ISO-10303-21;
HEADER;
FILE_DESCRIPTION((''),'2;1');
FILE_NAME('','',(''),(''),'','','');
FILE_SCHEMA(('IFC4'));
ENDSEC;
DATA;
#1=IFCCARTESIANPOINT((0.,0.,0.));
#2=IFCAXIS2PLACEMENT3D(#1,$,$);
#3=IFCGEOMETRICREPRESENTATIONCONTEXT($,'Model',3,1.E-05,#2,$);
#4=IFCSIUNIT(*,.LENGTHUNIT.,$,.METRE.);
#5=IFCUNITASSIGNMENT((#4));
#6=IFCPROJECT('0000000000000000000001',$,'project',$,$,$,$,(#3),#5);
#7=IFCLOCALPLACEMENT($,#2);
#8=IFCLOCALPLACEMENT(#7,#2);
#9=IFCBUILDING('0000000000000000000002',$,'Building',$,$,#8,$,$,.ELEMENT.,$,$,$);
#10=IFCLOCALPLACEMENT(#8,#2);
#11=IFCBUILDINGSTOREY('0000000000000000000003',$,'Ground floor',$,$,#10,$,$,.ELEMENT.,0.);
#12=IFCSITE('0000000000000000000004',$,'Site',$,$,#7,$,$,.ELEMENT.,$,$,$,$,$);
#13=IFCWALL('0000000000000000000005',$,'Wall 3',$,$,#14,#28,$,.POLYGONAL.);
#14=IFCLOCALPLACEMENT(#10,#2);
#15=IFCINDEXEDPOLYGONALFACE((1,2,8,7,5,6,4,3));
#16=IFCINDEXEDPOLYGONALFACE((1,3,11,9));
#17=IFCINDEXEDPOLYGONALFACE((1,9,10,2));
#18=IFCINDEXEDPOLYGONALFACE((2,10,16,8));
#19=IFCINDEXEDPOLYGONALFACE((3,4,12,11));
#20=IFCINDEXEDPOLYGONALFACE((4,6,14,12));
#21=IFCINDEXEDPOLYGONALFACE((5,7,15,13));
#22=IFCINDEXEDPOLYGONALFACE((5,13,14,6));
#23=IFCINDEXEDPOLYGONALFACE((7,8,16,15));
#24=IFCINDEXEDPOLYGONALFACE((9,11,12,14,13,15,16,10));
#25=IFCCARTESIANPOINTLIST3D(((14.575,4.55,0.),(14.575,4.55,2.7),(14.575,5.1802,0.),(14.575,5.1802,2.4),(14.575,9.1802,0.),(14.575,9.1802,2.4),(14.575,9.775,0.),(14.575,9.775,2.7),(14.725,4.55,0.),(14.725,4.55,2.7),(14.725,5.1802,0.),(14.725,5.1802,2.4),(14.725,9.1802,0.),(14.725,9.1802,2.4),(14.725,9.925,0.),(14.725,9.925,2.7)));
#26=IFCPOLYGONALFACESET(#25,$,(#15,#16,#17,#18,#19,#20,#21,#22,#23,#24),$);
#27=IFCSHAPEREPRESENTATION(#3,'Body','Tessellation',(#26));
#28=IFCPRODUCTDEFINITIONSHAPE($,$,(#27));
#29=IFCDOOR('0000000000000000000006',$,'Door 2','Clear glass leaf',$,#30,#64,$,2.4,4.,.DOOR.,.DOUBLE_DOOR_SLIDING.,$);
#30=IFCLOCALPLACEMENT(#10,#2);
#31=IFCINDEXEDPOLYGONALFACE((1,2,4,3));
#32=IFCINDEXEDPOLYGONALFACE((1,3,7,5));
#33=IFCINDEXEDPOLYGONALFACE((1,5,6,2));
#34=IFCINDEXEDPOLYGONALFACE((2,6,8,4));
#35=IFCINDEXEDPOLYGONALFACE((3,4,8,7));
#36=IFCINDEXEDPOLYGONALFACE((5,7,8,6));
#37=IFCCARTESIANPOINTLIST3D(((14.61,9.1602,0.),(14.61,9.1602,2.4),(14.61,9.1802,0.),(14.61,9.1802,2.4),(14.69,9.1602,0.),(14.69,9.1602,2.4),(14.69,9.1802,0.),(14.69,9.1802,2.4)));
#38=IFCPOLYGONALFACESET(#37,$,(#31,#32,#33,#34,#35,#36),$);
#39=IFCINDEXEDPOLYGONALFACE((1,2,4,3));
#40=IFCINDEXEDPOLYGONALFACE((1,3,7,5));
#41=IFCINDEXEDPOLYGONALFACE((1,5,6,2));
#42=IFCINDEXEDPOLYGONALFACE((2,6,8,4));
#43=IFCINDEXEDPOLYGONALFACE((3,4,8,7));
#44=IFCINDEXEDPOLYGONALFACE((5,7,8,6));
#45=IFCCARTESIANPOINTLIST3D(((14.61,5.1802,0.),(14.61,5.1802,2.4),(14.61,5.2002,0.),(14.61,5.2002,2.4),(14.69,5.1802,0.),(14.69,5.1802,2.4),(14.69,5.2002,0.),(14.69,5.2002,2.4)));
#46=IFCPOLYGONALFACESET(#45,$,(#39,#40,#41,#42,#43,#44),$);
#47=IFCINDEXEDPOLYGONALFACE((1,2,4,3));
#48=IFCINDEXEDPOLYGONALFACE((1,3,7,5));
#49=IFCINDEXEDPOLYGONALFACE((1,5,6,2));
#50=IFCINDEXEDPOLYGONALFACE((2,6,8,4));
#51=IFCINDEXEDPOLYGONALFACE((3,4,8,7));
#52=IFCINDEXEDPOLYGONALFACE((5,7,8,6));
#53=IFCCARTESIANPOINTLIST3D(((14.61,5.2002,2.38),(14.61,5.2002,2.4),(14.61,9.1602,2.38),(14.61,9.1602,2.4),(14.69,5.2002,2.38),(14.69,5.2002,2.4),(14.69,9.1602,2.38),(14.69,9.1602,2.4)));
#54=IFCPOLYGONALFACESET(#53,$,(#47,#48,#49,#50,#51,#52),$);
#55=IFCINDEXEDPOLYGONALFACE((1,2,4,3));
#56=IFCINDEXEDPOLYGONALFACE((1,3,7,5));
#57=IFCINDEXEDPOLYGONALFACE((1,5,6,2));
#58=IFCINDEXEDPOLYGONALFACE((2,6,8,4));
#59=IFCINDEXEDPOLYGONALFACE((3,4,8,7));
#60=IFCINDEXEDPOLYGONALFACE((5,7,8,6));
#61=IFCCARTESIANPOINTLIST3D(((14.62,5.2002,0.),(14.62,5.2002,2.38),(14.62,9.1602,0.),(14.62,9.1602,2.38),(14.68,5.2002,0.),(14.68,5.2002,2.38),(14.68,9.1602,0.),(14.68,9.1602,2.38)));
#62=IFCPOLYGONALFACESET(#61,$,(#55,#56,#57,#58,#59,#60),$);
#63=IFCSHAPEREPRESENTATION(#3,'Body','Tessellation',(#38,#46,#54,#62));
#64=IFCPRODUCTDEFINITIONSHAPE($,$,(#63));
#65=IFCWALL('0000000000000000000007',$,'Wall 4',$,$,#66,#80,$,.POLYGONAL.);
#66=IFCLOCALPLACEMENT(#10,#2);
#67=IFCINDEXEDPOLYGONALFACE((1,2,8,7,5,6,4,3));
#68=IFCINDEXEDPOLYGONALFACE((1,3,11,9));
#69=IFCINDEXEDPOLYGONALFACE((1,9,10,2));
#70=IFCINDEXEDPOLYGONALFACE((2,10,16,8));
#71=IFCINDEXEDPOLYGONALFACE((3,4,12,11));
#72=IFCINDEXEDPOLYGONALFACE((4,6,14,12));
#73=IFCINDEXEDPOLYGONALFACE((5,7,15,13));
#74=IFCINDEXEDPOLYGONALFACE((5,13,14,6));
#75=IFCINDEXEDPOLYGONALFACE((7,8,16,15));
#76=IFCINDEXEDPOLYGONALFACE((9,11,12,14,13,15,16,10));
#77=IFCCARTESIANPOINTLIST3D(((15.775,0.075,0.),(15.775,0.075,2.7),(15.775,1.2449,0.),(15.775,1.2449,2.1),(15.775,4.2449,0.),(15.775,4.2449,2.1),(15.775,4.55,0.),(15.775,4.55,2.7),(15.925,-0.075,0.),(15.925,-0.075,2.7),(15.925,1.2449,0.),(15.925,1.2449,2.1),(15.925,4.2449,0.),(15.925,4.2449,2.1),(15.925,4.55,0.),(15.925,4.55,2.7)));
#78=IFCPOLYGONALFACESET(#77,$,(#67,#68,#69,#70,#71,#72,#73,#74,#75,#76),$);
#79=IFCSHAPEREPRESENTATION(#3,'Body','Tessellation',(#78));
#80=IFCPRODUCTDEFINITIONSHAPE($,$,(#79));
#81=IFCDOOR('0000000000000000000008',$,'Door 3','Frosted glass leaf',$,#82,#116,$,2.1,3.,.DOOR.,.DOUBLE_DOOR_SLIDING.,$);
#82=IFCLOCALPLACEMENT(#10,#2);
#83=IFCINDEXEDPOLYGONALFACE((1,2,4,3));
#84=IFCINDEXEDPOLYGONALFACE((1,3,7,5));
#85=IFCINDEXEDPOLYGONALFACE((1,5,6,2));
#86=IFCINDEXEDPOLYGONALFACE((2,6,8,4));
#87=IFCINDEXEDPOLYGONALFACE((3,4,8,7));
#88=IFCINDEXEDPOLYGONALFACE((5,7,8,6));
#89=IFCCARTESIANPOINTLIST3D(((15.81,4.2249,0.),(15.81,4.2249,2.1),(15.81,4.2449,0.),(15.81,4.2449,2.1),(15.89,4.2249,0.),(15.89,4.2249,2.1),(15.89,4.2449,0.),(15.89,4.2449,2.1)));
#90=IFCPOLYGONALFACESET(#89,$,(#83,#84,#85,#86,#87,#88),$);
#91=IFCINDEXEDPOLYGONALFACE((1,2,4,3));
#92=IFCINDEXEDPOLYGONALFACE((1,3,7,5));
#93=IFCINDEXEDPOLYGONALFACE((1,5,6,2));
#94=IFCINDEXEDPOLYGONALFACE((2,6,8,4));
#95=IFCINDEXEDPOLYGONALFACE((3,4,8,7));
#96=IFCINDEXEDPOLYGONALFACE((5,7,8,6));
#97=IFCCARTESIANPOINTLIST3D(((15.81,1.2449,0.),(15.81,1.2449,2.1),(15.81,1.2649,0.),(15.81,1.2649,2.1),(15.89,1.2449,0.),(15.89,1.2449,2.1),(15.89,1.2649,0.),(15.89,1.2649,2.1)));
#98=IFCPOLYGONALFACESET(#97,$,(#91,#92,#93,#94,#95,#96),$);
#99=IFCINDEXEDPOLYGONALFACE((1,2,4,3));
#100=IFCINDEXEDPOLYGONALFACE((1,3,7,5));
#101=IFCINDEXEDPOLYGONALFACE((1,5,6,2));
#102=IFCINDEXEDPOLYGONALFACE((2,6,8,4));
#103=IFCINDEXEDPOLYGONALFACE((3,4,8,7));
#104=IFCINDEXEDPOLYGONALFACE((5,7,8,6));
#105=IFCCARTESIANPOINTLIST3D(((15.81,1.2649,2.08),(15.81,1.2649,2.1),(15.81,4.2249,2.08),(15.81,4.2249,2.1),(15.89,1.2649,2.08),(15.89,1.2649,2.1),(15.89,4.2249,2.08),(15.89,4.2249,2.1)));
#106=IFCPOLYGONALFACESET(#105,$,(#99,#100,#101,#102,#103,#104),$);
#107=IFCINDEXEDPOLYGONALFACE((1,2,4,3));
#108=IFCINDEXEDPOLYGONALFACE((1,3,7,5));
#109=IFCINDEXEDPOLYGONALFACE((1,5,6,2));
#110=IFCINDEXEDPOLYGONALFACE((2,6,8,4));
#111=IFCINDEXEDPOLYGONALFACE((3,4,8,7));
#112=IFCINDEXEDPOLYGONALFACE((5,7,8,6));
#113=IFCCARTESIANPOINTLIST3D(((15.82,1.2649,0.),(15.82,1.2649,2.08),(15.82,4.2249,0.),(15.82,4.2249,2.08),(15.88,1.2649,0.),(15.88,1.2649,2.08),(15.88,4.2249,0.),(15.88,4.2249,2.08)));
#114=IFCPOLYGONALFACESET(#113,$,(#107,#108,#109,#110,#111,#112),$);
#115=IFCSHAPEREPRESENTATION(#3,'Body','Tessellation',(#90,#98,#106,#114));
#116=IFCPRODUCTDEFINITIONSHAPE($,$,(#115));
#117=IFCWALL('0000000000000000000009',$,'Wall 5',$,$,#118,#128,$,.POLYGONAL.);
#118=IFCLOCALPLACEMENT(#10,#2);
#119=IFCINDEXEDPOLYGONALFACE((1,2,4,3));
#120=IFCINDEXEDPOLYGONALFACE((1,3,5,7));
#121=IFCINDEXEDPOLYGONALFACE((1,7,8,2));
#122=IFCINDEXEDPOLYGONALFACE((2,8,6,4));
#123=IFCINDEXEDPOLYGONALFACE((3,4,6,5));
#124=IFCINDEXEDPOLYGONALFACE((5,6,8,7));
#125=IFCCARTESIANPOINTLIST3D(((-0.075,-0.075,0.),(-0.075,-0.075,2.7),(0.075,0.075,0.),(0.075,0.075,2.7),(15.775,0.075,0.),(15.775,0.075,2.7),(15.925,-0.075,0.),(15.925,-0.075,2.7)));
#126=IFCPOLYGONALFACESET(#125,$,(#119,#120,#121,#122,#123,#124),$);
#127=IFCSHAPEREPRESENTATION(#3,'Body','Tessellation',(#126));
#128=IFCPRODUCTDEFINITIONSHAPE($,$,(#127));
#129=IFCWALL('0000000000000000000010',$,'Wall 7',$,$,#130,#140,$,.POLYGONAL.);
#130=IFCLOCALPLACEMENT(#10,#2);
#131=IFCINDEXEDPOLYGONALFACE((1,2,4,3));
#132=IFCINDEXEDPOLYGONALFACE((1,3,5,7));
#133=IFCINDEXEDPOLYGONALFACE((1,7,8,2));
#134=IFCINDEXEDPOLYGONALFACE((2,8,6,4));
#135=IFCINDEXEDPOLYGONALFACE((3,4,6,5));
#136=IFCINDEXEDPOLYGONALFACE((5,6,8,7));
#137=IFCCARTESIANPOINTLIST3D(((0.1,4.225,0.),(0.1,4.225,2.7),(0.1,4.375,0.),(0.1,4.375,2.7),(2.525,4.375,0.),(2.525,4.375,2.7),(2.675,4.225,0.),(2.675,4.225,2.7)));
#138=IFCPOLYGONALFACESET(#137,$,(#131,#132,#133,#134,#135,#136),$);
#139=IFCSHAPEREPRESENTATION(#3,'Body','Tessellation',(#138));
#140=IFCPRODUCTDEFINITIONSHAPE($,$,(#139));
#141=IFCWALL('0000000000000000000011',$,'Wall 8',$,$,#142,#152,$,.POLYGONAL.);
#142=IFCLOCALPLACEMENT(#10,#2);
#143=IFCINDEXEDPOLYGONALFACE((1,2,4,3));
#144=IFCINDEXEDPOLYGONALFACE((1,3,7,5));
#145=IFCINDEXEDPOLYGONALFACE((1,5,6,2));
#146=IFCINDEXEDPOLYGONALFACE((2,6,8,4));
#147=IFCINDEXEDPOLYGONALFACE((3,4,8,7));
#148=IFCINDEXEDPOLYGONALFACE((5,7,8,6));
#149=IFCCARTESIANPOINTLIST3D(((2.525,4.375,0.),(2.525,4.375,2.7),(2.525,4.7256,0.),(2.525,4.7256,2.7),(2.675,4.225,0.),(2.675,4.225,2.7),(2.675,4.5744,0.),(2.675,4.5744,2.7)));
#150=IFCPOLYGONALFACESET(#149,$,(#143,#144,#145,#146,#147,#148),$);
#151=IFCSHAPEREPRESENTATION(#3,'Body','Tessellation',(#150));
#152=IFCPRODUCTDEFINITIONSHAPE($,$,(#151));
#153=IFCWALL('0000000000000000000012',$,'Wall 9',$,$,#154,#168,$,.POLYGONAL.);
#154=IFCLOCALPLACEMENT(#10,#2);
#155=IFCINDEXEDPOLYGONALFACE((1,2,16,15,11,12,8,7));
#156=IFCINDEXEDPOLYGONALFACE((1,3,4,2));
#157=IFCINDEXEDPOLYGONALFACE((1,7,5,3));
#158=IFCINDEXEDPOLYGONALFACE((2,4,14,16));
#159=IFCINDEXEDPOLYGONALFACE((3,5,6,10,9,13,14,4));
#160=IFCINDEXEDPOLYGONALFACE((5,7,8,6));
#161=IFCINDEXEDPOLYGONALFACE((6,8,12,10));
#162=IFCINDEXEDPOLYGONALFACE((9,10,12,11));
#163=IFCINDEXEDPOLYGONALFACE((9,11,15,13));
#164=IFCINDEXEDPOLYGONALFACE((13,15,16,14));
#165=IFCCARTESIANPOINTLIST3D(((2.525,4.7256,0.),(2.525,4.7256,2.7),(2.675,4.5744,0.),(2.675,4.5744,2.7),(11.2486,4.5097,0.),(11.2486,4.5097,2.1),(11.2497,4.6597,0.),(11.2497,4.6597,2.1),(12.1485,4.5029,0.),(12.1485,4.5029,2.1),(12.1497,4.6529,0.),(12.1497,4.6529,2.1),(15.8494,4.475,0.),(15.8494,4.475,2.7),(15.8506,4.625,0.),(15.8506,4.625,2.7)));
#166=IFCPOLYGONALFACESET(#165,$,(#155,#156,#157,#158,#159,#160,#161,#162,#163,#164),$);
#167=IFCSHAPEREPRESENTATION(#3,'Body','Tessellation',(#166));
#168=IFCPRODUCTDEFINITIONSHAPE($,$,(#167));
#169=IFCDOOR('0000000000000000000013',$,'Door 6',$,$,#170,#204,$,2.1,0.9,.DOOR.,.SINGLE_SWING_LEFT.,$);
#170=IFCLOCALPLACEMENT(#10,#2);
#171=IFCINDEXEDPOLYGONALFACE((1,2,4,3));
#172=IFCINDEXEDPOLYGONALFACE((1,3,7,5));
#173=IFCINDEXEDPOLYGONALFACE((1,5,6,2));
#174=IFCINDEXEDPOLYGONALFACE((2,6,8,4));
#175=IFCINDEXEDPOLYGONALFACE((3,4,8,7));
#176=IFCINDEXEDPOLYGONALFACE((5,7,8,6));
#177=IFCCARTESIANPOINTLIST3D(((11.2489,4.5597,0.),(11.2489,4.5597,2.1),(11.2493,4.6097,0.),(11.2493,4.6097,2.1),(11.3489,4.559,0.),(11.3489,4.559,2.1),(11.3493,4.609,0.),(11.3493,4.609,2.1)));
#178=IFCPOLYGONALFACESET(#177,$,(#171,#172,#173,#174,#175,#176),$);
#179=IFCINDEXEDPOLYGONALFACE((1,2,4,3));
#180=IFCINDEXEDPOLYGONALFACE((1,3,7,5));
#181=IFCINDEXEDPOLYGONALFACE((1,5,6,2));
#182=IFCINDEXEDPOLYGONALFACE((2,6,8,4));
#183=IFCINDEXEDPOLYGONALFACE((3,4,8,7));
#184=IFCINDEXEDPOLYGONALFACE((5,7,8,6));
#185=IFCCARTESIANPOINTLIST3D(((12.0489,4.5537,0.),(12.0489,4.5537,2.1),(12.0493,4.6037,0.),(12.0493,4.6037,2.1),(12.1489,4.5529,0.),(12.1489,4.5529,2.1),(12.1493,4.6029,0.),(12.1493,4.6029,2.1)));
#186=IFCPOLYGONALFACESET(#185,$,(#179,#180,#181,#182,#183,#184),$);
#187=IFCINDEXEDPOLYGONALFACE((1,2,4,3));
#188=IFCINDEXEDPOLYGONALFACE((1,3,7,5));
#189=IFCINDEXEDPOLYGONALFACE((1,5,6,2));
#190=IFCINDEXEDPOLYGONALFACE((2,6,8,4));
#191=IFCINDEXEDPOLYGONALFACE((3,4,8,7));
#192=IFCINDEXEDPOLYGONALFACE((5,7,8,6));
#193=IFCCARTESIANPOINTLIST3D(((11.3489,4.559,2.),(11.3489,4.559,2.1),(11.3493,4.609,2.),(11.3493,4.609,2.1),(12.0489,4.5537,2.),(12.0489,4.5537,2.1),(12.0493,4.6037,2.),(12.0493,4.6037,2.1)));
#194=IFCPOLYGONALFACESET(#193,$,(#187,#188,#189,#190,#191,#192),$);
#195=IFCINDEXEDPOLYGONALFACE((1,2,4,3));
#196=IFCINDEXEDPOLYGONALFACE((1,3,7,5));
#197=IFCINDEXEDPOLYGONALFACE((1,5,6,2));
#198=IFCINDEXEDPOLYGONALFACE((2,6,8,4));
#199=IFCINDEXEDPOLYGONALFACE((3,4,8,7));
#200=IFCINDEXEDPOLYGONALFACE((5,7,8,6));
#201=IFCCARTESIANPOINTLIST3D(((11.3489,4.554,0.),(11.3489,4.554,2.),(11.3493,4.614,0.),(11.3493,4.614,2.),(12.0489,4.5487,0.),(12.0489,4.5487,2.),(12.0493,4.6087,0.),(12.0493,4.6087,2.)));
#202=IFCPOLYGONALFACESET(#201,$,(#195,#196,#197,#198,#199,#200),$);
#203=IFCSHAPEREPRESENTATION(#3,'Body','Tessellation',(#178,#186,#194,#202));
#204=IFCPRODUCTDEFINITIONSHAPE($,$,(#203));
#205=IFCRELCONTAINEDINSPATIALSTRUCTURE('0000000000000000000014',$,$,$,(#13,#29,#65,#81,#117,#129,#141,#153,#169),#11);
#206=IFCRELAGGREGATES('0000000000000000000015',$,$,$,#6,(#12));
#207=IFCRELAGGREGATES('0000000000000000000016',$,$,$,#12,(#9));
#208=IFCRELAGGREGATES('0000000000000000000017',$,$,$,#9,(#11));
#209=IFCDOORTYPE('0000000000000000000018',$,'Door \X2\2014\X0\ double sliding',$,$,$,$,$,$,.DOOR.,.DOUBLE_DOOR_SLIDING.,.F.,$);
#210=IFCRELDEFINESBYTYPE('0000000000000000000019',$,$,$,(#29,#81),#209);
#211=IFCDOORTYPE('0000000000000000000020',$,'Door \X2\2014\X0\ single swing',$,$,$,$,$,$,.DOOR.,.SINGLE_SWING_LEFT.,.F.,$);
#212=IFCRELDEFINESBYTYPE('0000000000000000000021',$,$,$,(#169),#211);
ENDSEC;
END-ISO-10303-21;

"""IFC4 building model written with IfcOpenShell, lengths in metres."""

from ifc_helpers import new_model, si_unit, frame, frame_2d, origin, origin_with_axes, place, context, project, spatial, polyline, rectangle, outline, extrude, type_object, element, fill, save


model = new_model("IFC4")

# Units and contexts
model_context = context("Model", 3, precision=1e-05, world=origin())
ifc_project = project(units=[si_unit("LENGTHUNIT", "METRE")], contexts=[model_context])

# Site, building, storey
site_placement = place(None, origin())
site = spatial("IfcSite", under=ifc_project, at=site_placement, Name="Site", CompositionType="ELEMENT")
building_placement = place(site_placement, origin())
building = spatial("IfcBuilding", under=site, at=building_placement, Name="Building", CompositionType="ELEMENT")
storey_placement = place(building_placement, origin())
storey = spatial("IfcBuildingStorey", under=building, at=storey_placement, Name="Ground floor", CompositionType="ELEMENT", Elevation=0.0)

# Shared definitions
door_type_1 = type_object("IfcDoorType", Name="Door — single swing", OperationType="SINGLE_SWING_LEFT", ParameterTakesPrecedence=False, PredefinedType="DOOR")

# Walls, openings, doors
wall_1_placement = place(storey_placement, origin_with_axes())
wall_1 = element("IfcWall", 1, at=wall_1_placement, inside=storey, Name="Wall 3", PredefinedType="POLYGONAL", context=model_context, shape_type="SweptSolid", body=[
    extrude(outline(polyline([(14.725, 9.925), (14.575, 9.775), (14.575, 4.55), (14.725, 4.55), (14.725, 9.925)])), origin(), (0.0, 0.0, 1.0), 2.7),
])
opening_1_placement = place(storey_placement, frame((14.65, 9.1802, 0.0), z_axis=(0.0, 0.0, 1.0), x_axis=(0.0, -1.0, 0.0)))
opening_1 = element("IfcOpeningElement", 2, at=opening_1_placement, cuts=wall_1, PredefinedType="OPENING", context=model_context, shape_type="SweptSolid", body=[
    extrude(rectangle(XDim=4.0, YDim=0.21, at=frame_2d((2.0, 0.0))), origin(), (0.0, 0.0, 1.0), 2.4),
])
door_type_2 = type_object("IfcDoorType", Name="Door — double sliding", OperationType="DOUBLE_DOOR_SLIDING", ParameterTakesPrecedence=False, PredefinedType="DOOR")
door_1_placement = place(storey_placement, frame((14.65, 9.1802, 0.0), z_axis=(0.0, 0.0, 1.0), x_axis=(0.0, -1.0, 0.0)))
door_1 = element("IfcDoor", 3, at=door_1_placement, inside=storey, type_object=door_type_2, Name="Door 2", Description="Clear glass leaf", OperationType="DOUBLE_DOOR_SLIDING", OverallHeight=2.4, OverallWidth=4.0, PredefinedType="DOOR", context=model_context, shape_type="SweptSolid", body=[
    extrude(rectangle(XDim=0.02, YDim=0.08, at=frame_2d((0.01, 0.0))), origin(), (0.0, 0.0, 1.0), 2.4),
    extrude(rectangle(XDim=0.02, YDim=0.08, at=frame_2d((3.99, 0.0))), origin(), (0.0, 0.0, 1.0), 2.4),
    extrude(rectangle(XDim=3.96, YDim=0.08, at=frame_2d((2.0, 0.0))), frame((0.0, 0.0, 2.38)), (0.0, 0.0, 1.0), 0.02),
    extrude(rectangle(XDim=3.96, YDim=0.06, at=frame_2d((2.0, 0.0))), origin(), (0.0, 0.0, 1.0), 2.38),
])
fill(opening_1, door_1)
wall_2_placement = place(storey_placement, origin_with_axes())
wall_2 = element("IfcWall", 4, at=wall_2_placement, inside=storey, Name="Wall 4", PredefinedType="POLYGONAL", context=model_context, shape_type="SweptSolid", body=[
    extrude(outline(polyline([(15.925, 4.55), (15.775, 4.55), (15.775, 0.075), (15.925, -0.075), (15.925, 4.55)])), origin(), (0.0, 0.0, 1.0), 2.7),
])
opening_2_placement = place(storey_placement, frame((15.85, 4.2449, 0.0), z_axis=(0.0, 0.0, 1.0), x_axis=(0.0, -1.0, 0.0)))
opening_2 = element("IfcOpeningElement", 5, at=opening_2_placement, cuts=wall_2, PredefinedType="OPENING", context=model_context, shape_type="SweptSolid", body=[
    extrude(rectangle(XDim=3.0, YDim=0.21, at=frame_2d((1.5, 0.0))), origin(), (0.0, 0.0, 1.0), 2.1),
])
door_2_placement = place(storey_placement, frame((15.85, 4.2449, 0.0), z_axis=(0.0, 0.0, 1.0), x_axis=(0.0, -1.0, 0.0)))
door_2 = element("IfcDoor", 6, at=door_2_placement, inside=storey, type_object=door_type_2, Name="Door 3", Description="Frosted glass leaf", OperationType="DOUBLE_DOOR_SLIDING", OverallHeight=2.1, OverallWidth=3.0, PredefinedType="DOOR", context=model_context, shape_type="SweptSolid", body=[
    extrude(rectangle(XDim=0.02, YDim=0.08, at=frame_2d((0.01, 0.0))), origin(), (0.0, 0.0, 1.0), 2.1),
    extrude(rectangle(XDim=0.02, YDim=0.08, at=frame_2d((2.99, 0.0))), origin(), (0.0, 0.0, 1.0), 2.1),
    extrude(rectangle(XDim=2.96, YDim=0.08, at=frame_2d((1.5, 0.0))), frame((0.0, 0.0, 2.08)), (0.0, 0.0, 1.0), 0.02),
    extrude(rectangle(XDim=2.96, YDim=0.06, at=frame_2d((1.5, 0.0))), origin(), (0.0, 0.0, 1.0), 2.08),
])
fill(opening_2, door_2)

# Walls
wall_3_placement = place(storey_placement, origin_with_axes())
element("IfcWall", 7, at=wall_3_placement, inside=storey, Name="Wall 5", PredefinedType="POLYGONAL", context=model_context, shape_type="SweptSolid", body=[
    extrude(outline(polyline([(15.925, -0.075), (15.775, 0.075), (0.075, 0.075), (-0.075, -0.075), (15.925, -0.075)])), origin(), (0.0, 0.0, 1.0), 2.7),
])
wall_4_placement = place(storey_placement, origin_with_axes())
element("IfcWall", 8, at=wall_4_placement, inside=storey, Name="Wall 7", PredefinedType="POLYGONAL", context=model_context, shape_type="SweptSolid", body=[
    extrude(outline(polyline([(0.1, 4.375), (0.1, 4.225), (2.675, 4.225), (2.525, 4.375), (0.1, 4.375)])), origin(), (0.0, 0.0, 1.0), 2.7),
])
wall_5_placement = place(storey_placement, origin_with_axes())
element("IfcWall", 9, at=wall_5_placement, inside=storey, Name="Wall 8", PredefinedType="POLYGONAL", context=model_context, shape_type="SweptSolid", body=[
    extrude(outline(polyline([(2.525, 4.375), (2.675, 4.225), (2.675, 4.5744), (2.525, 4.7256), (2.525, 4.375)])), origin(), (0.0, 0.0, 1.0), 2.7),
])

# Wall, opening, door
wall_6_placement = place(storey_placement, origin_with_axes())
wall_6 = element("IfcWall", 10, at=wall_6_placement, inside=storey, Name="Wall 9", PredefinedType="POLYGONAL", context=model_context, shape_type="SweptSolid", body=[
    extrude(outline(polyline([(2.525, 4.7256), (2.675, 4.5744), (15.8494, 4.475), (15.8506, 4.625), (2.525, 4.7256)])), origin(), (0.0, 0.0, 1.0), 2.7),
])
opening_3_placement = place(storey_placement, frame((11.2491, 4.5847, 0.0), z_axis=(0.0, 0.0, 1.0), x_axis=(0.999972, -0.007547, 0.0)))
opening_3 = element("IfcOpeningElement", 11, at=opening_3_placement, cuts=wall_6, PredefinedType="OPENING", context=model_context, shape_type="SweptSolid", body=[
    extrude(rectangle(XDim=0.9, YDim=0.21, at=frame_2d((0.45, 0.0))), origin(), (0.0, 0.0, 1.0), 2.1),
])
door_3_placement = place(storey_placement, frame((11.2491, 4.5847, 0.0), z_axis=(0.0, 0.0, 1.0), x_axis=(0.999972, -0.007547, 0.0)))
door_3 = element("IfcDoor", 12, at=door_3_placement, inside=storey, type_object=door_type_1, Name="Door 6", OperationType="SINGLE_SWING_LEFT", OverallHeight=2.1, OverallWidth=0.9, PredefinedType="DOOR", context=model_context, shape_type="SweptSolid", body=[
    extrude(rectangle(XDim=0.1, YDim=0.05, at=frame_2d((0.05, 0.0))), origin(), (0.0, 0.0, 1.0), 2.1),
    extrude(rectangle(XDim=0.1, YDim=0.05, at=frame_2d((0.85, 0.0))), origin(), (0.0, 0.0, 1.0), 2.1),
    extrude(rectangle(XDim=0.7, YDim=0.05, at=frame_2d((0.45, 0.0))), frame((0.0, 0.0, 2.0)), (0.0, 0.0, 1.0), 0.1),
    extrude(rectangle(XDim=0.7, YDim=0.06, at=frame_2d((0.45, 0.0))), origin(), (0.0, 0.0, 1.0), 2.0),
])
fill(opening_3, door_3)

save(model, "model.ifc")
